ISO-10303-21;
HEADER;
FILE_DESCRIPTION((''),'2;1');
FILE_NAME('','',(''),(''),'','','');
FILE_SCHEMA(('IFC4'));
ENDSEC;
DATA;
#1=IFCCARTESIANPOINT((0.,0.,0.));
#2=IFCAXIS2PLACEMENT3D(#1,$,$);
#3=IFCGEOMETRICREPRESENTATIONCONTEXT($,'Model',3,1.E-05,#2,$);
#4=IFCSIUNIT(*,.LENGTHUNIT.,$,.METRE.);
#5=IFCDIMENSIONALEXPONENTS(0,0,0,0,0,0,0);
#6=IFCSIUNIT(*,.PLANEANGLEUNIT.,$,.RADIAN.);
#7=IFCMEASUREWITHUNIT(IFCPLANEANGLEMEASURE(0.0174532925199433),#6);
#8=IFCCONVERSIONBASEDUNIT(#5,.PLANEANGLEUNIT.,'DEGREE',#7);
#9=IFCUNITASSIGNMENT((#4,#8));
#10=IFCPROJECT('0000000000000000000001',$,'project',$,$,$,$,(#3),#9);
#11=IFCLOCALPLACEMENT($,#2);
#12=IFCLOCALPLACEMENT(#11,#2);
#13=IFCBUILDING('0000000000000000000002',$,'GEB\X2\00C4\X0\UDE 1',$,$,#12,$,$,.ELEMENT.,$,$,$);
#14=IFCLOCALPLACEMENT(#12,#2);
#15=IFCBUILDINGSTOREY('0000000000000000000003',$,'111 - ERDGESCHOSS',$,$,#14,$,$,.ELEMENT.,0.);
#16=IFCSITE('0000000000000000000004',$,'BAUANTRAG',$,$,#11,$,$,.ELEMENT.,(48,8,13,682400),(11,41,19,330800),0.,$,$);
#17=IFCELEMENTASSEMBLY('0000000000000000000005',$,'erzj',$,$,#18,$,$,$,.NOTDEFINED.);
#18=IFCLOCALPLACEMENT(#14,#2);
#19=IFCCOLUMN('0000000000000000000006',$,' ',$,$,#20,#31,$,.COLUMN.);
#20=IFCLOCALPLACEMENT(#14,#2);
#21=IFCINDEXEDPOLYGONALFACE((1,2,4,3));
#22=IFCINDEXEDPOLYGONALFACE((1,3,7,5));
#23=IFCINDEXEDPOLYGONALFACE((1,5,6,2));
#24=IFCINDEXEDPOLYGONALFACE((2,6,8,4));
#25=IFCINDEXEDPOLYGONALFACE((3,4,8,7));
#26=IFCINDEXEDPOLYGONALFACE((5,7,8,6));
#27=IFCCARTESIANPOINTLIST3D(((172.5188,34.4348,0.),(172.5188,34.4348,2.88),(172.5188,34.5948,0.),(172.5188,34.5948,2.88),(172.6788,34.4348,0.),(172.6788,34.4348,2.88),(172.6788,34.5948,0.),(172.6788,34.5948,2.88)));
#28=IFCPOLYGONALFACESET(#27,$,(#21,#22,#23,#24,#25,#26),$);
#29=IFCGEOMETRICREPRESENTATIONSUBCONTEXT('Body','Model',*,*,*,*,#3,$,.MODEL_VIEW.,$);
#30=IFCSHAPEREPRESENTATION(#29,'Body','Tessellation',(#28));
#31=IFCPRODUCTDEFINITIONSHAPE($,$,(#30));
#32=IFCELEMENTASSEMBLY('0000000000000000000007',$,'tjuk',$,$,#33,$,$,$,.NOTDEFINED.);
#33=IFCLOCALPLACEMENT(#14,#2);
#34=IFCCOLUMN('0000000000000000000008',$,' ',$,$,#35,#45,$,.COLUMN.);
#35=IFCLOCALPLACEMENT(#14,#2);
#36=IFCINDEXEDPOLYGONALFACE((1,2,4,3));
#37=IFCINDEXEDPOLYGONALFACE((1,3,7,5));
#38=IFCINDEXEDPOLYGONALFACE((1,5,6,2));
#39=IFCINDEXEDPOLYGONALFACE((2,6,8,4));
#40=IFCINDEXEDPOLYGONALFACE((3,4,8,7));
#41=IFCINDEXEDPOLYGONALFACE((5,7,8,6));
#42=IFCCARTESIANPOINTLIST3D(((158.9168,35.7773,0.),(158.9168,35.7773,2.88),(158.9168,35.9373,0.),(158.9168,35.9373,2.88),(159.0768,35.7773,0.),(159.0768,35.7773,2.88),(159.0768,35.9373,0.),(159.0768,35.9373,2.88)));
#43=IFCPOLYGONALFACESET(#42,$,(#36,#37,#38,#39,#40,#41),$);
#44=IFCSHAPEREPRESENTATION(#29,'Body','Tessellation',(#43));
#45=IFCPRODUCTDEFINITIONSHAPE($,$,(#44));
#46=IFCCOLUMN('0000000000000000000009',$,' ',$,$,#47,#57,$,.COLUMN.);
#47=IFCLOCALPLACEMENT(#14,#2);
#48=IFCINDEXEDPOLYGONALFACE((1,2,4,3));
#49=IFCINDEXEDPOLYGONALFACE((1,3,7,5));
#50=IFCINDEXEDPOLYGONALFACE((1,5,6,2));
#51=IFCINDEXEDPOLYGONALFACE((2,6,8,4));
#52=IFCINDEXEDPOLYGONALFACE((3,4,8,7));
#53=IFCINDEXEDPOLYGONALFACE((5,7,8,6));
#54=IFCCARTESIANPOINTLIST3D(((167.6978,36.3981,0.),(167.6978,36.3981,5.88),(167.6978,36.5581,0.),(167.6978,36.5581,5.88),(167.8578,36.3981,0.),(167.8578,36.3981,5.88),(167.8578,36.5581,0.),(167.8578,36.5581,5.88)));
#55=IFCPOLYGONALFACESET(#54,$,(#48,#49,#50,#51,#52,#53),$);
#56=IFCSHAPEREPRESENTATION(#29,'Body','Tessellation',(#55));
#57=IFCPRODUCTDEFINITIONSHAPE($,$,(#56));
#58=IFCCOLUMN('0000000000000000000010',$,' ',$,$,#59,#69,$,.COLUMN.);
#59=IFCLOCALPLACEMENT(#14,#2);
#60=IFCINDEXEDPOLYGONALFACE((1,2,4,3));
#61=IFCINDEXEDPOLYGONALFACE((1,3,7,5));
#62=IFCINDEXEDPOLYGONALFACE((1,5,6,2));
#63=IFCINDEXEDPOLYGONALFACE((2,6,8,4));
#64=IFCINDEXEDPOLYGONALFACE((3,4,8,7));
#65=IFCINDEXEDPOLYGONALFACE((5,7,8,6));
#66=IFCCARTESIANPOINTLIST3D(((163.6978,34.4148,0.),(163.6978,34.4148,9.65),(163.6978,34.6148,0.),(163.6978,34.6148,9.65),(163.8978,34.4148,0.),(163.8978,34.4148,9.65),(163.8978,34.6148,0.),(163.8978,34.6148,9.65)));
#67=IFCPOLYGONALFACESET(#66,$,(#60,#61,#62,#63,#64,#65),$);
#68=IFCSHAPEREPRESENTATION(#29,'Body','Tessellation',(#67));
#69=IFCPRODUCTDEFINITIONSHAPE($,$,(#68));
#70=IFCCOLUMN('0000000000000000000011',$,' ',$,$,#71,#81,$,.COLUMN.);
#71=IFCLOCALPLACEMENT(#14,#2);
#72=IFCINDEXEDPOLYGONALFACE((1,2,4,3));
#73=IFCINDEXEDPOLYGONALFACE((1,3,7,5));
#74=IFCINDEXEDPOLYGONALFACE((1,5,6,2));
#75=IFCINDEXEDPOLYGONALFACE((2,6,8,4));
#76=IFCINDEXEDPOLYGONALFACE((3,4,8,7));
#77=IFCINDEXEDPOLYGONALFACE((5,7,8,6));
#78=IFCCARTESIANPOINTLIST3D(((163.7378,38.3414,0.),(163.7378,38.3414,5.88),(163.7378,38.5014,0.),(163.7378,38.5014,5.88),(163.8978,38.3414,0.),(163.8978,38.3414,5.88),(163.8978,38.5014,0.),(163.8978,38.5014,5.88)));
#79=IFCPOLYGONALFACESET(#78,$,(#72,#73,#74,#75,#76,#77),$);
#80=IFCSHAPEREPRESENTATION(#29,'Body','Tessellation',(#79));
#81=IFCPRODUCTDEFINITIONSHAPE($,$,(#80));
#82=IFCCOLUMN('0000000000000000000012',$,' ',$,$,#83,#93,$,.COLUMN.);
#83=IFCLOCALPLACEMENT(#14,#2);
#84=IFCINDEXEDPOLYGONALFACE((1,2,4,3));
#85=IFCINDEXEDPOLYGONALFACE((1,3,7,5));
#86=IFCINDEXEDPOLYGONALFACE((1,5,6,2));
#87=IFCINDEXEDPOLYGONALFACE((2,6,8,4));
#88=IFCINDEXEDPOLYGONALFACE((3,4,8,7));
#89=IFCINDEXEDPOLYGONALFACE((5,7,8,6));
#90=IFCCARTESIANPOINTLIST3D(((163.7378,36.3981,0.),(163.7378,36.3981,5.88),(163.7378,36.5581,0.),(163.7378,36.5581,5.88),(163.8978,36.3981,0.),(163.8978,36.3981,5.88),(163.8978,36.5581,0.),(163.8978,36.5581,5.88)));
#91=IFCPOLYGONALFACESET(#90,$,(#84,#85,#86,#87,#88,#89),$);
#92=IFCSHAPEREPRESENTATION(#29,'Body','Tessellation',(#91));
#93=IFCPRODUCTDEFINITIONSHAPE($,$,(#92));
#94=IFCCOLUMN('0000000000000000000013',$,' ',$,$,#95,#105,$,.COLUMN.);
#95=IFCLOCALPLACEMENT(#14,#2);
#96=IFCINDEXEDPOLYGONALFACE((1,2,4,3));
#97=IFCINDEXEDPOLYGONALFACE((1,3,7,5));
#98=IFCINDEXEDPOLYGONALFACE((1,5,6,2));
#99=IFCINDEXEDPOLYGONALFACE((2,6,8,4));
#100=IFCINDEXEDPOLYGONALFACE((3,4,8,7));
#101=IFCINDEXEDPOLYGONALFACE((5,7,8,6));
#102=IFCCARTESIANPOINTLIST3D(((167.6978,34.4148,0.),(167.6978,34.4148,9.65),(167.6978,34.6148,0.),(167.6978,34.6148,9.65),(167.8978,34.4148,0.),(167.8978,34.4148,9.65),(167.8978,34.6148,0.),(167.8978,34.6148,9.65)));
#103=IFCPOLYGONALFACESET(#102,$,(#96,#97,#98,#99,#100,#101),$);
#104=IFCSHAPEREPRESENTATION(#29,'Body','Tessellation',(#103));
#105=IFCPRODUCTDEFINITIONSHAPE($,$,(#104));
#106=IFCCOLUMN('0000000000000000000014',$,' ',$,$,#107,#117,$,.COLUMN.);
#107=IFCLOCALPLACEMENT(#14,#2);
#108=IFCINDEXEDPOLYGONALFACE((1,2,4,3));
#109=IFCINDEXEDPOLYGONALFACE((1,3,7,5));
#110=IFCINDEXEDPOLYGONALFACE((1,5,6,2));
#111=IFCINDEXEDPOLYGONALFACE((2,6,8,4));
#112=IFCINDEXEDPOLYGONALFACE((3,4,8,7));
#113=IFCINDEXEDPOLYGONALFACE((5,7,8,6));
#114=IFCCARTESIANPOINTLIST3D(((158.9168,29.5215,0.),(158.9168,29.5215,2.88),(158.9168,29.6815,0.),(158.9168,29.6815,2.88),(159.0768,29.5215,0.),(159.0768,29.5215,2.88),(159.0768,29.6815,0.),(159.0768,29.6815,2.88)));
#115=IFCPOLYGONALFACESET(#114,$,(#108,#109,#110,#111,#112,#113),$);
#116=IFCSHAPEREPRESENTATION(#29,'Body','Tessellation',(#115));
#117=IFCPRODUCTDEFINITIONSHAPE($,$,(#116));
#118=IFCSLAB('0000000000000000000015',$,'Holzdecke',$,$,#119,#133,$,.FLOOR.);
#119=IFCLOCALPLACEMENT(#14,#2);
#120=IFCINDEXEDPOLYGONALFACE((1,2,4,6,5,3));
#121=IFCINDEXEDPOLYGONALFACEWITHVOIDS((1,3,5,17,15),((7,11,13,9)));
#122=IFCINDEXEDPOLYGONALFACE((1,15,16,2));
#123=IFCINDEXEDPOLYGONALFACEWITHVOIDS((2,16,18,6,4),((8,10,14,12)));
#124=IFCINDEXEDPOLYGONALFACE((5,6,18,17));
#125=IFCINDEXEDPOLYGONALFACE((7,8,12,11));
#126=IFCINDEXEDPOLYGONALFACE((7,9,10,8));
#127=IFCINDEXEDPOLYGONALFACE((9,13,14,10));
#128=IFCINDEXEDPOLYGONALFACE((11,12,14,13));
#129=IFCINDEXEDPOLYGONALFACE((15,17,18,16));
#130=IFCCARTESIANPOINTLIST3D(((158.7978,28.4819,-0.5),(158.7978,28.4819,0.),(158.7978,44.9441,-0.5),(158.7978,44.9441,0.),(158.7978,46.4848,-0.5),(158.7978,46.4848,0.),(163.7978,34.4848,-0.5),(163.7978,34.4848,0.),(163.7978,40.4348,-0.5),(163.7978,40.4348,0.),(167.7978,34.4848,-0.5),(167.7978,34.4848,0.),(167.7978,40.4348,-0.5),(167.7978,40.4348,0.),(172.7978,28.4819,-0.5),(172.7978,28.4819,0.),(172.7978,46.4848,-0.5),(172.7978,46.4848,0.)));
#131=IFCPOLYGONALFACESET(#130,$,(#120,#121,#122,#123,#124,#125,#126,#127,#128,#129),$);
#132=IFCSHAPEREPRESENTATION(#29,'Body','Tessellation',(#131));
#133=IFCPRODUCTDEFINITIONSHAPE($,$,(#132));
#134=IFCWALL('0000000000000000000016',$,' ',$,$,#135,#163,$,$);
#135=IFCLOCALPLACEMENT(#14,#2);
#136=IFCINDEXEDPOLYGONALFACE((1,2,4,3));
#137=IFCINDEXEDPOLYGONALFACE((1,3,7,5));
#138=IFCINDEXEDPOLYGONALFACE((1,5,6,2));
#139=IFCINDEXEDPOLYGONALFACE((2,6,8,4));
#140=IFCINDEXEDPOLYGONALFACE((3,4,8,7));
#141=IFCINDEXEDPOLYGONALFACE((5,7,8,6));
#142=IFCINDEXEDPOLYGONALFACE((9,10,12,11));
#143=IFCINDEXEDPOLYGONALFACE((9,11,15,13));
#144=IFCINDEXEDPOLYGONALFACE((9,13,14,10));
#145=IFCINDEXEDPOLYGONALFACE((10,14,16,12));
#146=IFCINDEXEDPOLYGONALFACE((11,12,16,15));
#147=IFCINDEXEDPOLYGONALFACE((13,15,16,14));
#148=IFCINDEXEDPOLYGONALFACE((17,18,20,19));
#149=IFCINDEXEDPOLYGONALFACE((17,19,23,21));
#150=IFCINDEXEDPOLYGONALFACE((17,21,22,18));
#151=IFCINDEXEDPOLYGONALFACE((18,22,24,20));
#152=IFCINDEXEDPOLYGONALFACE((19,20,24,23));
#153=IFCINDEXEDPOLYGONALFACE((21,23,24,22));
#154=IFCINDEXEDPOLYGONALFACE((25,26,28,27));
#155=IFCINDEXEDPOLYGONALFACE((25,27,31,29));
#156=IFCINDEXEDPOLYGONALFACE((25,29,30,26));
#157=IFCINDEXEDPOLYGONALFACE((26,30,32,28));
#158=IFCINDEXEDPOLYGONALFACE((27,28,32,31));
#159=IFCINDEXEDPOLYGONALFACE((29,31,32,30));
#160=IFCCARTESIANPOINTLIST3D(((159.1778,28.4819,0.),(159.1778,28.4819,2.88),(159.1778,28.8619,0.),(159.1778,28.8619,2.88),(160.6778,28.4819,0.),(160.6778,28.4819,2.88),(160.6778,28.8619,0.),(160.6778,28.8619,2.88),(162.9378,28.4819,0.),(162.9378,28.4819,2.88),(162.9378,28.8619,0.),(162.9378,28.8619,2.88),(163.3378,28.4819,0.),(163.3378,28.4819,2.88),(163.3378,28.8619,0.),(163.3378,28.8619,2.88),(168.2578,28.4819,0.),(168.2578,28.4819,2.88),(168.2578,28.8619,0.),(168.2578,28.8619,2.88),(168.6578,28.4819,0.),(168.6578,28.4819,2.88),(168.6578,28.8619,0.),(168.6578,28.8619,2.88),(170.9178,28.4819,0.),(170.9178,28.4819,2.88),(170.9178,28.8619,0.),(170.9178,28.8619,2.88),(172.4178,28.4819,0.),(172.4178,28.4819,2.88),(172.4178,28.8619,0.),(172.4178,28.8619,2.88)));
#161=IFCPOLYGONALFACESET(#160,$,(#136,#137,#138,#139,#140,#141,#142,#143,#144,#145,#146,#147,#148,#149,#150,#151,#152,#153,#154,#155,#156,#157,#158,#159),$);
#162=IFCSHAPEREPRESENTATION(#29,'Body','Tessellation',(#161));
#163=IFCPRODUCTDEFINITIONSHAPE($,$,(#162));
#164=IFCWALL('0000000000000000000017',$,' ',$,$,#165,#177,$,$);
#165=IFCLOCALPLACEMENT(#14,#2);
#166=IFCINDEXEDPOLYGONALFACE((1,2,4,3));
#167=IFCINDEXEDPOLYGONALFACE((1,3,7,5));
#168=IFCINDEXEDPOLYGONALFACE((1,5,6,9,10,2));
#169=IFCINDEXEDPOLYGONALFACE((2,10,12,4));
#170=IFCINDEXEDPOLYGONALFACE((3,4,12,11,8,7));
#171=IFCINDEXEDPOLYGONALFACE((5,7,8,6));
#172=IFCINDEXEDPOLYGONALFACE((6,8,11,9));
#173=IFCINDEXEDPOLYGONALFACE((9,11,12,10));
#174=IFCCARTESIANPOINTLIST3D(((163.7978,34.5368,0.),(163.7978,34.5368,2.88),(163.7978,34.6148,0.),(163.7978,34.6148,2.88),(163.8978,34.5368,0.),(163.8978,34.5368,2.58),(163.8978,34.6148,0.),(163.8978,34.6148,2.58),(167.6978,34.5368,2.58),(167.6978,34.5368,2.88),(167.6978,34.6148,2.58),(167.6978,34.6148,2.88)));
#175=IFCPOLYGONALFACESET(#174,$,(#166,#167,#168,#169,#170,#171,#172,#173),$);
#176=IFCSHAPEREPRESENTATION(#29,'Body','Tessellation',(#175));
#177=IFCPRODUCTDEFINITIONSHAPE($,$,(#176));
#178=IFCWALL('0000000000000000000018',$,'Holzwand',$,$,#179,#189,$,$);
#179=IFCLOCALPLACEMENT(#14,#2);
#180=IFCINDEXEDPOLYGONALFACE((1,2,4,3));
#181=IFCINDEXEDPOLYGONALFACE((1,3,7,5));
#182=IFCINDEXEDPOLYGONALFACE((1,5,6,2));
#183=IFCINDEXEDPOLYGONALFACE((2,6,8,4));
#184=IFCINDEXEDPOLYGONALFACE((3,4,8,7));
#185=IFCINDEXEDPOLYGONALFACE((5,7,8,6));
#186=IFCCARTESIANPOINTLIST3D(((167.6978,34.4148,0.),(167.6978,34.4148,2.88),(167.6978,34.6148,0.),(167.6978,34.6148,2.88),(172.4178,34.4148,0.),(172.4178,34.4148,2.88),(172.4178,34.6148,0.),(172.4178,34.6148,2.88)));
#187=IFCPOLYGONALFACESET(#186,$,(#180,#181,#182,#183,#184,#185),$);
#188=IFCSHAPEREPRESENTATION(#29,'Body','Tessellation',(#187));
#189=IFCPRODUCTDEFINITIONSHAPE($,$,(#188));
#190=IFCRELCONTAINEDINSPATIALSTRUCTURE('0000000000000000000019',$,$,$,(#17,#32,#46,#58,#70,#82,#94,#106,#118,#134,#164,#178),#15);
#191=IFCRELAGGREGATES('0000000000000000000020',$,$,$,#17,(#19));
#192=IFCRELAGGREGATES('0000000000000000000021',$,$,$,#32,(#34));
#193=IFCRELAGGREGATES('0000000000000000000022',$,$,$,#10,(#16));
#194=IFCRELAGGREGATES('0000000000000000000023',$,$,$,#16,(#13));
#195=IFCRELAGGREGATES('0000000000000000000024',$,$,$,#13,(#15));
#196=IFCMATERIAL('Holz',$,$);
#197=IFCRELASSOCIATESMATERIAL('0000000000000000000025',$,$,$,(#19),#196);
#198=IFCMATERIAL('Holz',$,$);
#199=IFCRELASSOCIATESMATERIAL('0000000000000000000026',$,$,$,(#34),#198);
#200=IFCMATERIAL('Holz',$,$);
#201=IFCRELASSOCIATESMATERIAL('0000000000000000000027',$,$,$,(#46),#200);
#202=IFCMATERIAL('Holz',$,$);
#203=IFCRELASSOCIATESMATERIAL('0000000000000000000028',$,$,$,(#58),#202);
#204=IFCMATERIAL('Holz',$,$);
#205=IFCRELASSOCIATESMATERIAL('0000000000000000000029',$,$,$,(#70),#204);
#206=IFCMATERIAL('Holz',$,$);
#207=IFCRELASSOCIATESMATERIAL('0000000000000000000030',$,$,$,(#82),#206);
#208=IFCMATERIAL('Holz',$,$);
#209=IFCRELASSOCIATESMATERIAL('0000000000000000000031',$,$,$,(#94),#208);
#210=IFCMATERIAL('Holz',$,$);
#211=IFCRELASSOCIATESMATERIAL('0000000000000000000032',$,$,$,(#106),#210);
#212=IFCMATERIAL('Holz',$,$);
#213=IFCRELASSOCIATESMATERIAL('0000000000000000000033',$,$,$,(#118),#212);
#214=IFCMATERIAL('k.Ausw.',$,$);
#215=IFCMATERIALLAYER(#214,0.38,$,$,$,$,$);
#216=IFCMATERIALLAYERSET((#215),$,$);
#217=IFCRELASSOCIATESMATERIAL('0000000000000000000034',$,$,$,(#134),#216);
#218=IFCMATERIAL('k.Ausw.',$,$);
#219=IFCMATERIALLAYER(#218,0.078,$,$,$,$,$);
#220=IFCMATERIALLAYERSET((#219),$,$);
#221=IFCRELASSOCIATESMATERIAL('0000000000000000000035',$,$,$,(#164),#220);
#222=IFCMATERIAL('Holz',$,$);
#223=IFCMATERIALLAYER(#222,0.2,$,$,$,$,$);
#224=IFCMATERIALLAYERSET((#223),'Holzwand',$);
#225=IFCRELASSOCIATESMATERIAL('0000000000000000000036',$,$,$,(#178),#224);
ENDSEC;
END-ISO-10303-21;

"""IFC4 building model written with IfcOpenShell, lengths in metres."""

from ifc_helpers import new_model, entity, si_unit, converted_unit, frame, frame_2d, origin, origin_with_axes, place, context, subcontext, project, spatial, polyline, rectangle, outline, extrude, material, layer, layer_set, layer_usage, element, aggregate, save


model = new_model("IFC4")

# Units and contexts
model_context = context("Model", 3, precision=1e-05, world=origin())
body_context = subcontext(model_context, "Body", "Model", "MODEL_VIEW")
ifc_project = project(units=[si_unit("LENGTHUNIT", "METRE"), converted_unit("PLANEANGLEUNIT", "DEGREE", entity("IfcPlaneAngleMeasure", 0.0174532925199433), si_unit("PLANEANGLEUNIT", "RADIAN"), dimensions=[0, 0, 0, 0, 0, 0, 0])], contexts=[model_context])

# Site, building, storey
site_placement = place(None, origin())
site = spatial("IfcSite", under=ifc_project, at=site_placement, Name="BAUANTRAG", CompositionType="ELEMENT", RefLatitude=(48, 8, 13, 682400), RefLongitude=(11, 41, 19, 330800), RefElevation=0.0)
building_placement = place(site_placement, origin())
building = spatial("IfcBuilding", under=site, at=building_placement, Name="GEBÄUDE 1", CompositionType="ELEMENT")
storey_placement = place(building_placement, origin())
storey = spatial("IfcBuildingStorey", under=building, at=storey_placement, Name="111 - ERDGESCHOSS", CompositionType="ELEMENT", Elevation=0.0)

# Element assemblies, columns
assembly_1_placement = place(storey_placement, origin())
assembly_1 = element("IfcElementAssembly", 1, at=assembly_1_placement, inside=storey, Name="erzj", PredefinedType="NOTDEFINED")
ifc_material_1 = material(Name="Holz")
column_1_placement = place(assembly_1_placement, frame((172.5188, 34.4348, 0.0)))
column_1 = element("IfcColumn", 2, at=column_1_placement, material=ifc_material_1, Name=" ", PredefinedType="COLUMN", context=body_context, shape_type="SweptSolid", body=[
    extrude(rectangle(XDim=0.16, YDim=0.16, at=frame_2d((0.08, 0.08), x_axis=(1.0, 0.0))), origin_with_axes(), (0.0, 0.0, 1.0), 2.88),
])
aggregate(assembly_1, [column_1])
assembly_2_placement = place(storey_placement, origin())
assembly_2 = element("IfcElementAssembly", 3, at=assembly_2_placement, inside=storey, Name="tjuk", PredefinedType="NOTDEFINED")
ifc_material_2 = material(Name="Holz")
column_2_placement = place(assembly_2_placement, frame((158.9168, 35.7773, 0.0)))
column_2 = element("IfcColumn", 4, at=column_2_placement, material=ifc_material_2, Name=" ", PredefinedType="COLUMN", context=body_context, shape_type="SweptSolid", body=[
    extrude(rectangle(XDim=0.16, YDim=0.16, at=frame_2d((0.08, 0.08), x_axis=(1.0, 0.0))), origin_with_axes(), (0.0, 0.0, 1.0), 2.88),
])
aggregate(assembly_2, [column_2])

# Columns
ifc_material_3 = material(Name="Holz")
column_3_placement = place(storey_placement, frame((167.6978, 36.3981, 0.0)))
element("IfcColumn", 5, at=column_3_placement, inside=storey, material=ifc_material_3, Name=" ", PredefinedType="COLUMN", context=body_context, shape_type="SweptSolid", body=[
    extrude(rectangle(XDim=0.16, YDim=0.16, at=frame_2d((0.08, 0.08), x_axis=(1.0, 0.0))), origin_with_axes(), (0.0, 0.0, 1.0), 5.88),
])
ifc_material_4 = material(Name="Holz")
column_4_placement = place(storey_placement, frame((163.6978, 34.4148, 0.0)))
element("IfcColumn", 6, at=column_4_placement, inside=storey, material=ifc_material_4, Name=" ", PredefinedType="COLUMN", context=body_context, shape_type="SweptSolid", body=[
    extrude(rectangle(XDim=0.2, YDim=0.2, at=frame_2d((0.1, 0.1), x_axis=(1.0, 0.0))), origin_with_axes(), (0.0, 0.0, 1.0), 9.65),
])
ifc_material_5 = material(Name="Holz")
column_5_placement = place(storey_placement, frame((163.7378, 38.3414, 0.0)))
element("IfcColumn", 7, at=column_5_placement, inside=storey, material=ifc_material_5, Name=" ", PredefinedType="COLUMN", context=body_context, shape_type="SweptSolid", body=[
    extrude(rectangle(XDim=0.16, YDim=0.16, at=frame_2d((0.08, 0.08), x_axis=(1.0, 0.0))), origin_with_axes(), (0.0, 0.0, 1.0), 5.88),
])
ifc_material_6 = material(Name="Holz")
column_6_placement = place(storey_placement, frame((163.7378, 36.3981, 0.0)))
element("IfcColumn", 8, at=column_6_placement, inside=storey, material=ifc_material_6, Name=" ", PredefinedType="COLUMN", context=body_context, shape_type="SweptSolid", body=[
    extrude(rectangle(XDim=0.16, YDim=0.16, at=frame_2d((0.08, 0.08), x_axis=(1.0, 0.0))), origin_with_axes(), (0.0, 0.0, 1.0), 5.88),
])
ifc_material_7 = material(Name="Holz")
column_7_placement = place(storey_placement, frame((167.6978, 34.4148, 0.0)))
element("IfcColumn", 9, at=column_7_placement, inside=storey, material=ifc_material_7, Name=" ", PredefinedType="COLUMN", context=body_context, shape_type="SweptSolid", body=[
    extrude(rectangle(XDim=0.2, YDim=0.2, at=frame_2d((0.1, 0.1), x_axis=(1.0, 0.0))), origin_with_axes(), (0.0, 0.0, 1.0), 9.65),
])
ifc_material_8 = material(Name="Holz")
column_8_placement = place(storey_placement, frame((158.9168, 29.5215, 0.0)))
element("IfcColumn", 10, at=column_8_placement, inside=storey, material=ifc_material_8, Name=" ", PredefinedType="COLUMN", context=body_context, shape_type="SweptSolid", body=[
    extrude(rectangle(XDim=0.16, YDim=0.16, at=frame_2d((0.08, 0.08), x_axis=(1.0, 0.0))), origin_with_axes(), (0.0, 0.0, 1.0), 2.88),
])

# Slab
ifc_material_9 = material(Name="Holz")
slab_1_placement = place(storey_placement, frame((158.7978, 28.4819, -0.5)))
element("IfcSlab", 11, at=slab_1_placement, inside=storey, material=ifc_material_9, Name="Holzdecke", PredefinedType="FLOOR", context=body_context, shape_type="SweptSolid", body=[
    extrude(outline(polyline([(0.0, 16.4622), (0.0, 0.0), (14.0, 0.0), (14.0, 18.0029), (0.0, 18.0029), (0.0, 16.4622)]), holes=[polyline([(5.0, 11.9529), (9.0, 11.9529), (9.0, 6.0029), (5.0, 6.0029), (5.0, 11.9529)])]), origin_with_axes(), (0.0, 0.0, 1.0), 0.5),
])

# Wall, openings
ifc_material_10 = material(Name="k.Ausw.")
ifc_layer_1 = layer(ifc_material_10, 0.38)
ifc_layer_set_1 = layer_set([ifc_layer_1])
ifc_layer_usage_1 = layer_usage(ifc_layer_set_1, "AXIS2", "POSITIVE", 0.0)
wall_1_placement = place(storey_placement, frame((159.1778, 28.4819, 0.0)))
wall_1 = element("IfcWall", 12, at=wall_1_placement, inside=storey, material=ifc_layer_usage_1, Name=" ", context=body_context, shape_type="SweptSolid", body=[
    extrude(rectangle(XDim=13.24, YDim=0.38, at=frame_2d((6.62, 0.19), x_axis=(1.0, 0.0))), origin_with_axes(), (0.0, 0.0, 1.0), 2.88),
])
opening_1_placement = place(wall_1_placement, frame((9.48, 0.0, 0.0), z_axis=(0.0, 1.0, 0.0), x_axis=(0.0, 0.0, 1.0)))
element("IfcOpeningElement", 13, at=opening_1_placement, cuts=wall_1, ObjectType="Opening", context=body_context, shape_type="SweptSolid", body=[
    extrude(outline(polyline([(0.0, 2.26), (2.88, 2.26), (2.88, 0.0), (0.0, 0.0), (0.0, 2.26)])), origin_with_axes(), (0.0, 0.0, 1.0), 0.38),
])
opening_2_placement = place(wall_1_placement, frame((1.5, 0.0, 0.0), z_axis=(0.0, 1.0, 0.0), x_axis=(0.0, 0.0, 1.0)))
element("IfcOpeningElement", 14, at=opening_2_placement, cuts=wall_1, ObjectType="Opening", context=body_context, shape_type="SweptSolid", body=[
    extrude(outline(polyline([(0.0, 2.26), (2.88, 2.26), (2.88, 0.0), (0.0, 0.0), (0.0, 2.26)])), origin_with_axes(), (0.0, 0.0, 1.0), 0.38),
])
opening_3_placement = place(wall_1_placement, frame((4.16, 0.0, 0.0), z_axis=(0.0, 1.0, 0.0), x_axis=(0.0, 0.0, 1.0)))
element("IfcOpeningElement", 15, at=opening_3_placement, cuts=wall_1, ObjectType="Opening", context=body_context, shape_type="SweptSolid", body=[
    extrude(outline(polyline([(0.0, 4.92), (2.88, 4.92), (2.88, 0.0), (0.0, 0.0), (0.0, 4.92)])), origin_with_axes(), (0.0, 0.0, 1.0), 0.38),
])

# Wall, opening
ifc_material_11 = material(Name="k.Ausw.")
ifc_layer_2 = layer(ifc_material_11, 0.078)
ifc_layer_set_2 = layer_set([ifc_layer_2])
ifc_layer_usage_2 = layer_usage(ifc_layer_set_2, "AXIS2", "POSITIVE", 0.0)
wall_2_placement = place(storey_placement, frame((163.7978, 34.5368, 0.0)))
wall_2 = element("IfcWall", 16, at=wall_2_placement, inside=storey, material=ifc_layer_usage_2, Name=" ", context=body_context, shape_type="SweptSolid", body=[
    extrude(rectangle(XDim=3.9, YDim=0.078, at=frame_2d((1.95, 0.039), x_axis=(1.0, 0.0))), origin_with_axes(), (0.0, 0.0, 1.0), 2.88),
])
opening_4_placement = place(wall_2_placement, frame((0.1, 0.0, -0.14), z_axis=(0.0, 1.0, 0.0), x_axis=(0.0, 0.0, 1.0)))
element("IfcOpeningElement", 17, at=opening_4_placement, cuts=wall_2, ObjectType="Opening", context=body_context, shape_type="SweptSolid", body=[
    extrude(outline(polyline([(0.0, 3.8), (2.72, 3.8), (2.72, 0.0), (0.0, 0.0), (0.0, 3.8)])), origin_with_axes(), (0.0, 0.0, 1.0), 0.078),
])

# Wall
ifc_material_12 = material(Name="Holz")
ifc_layer_3 = layer(ifc_material_12, 0.2)
ifc_layer_set_3 = layer_set([ifc_layer_3], Name="Holzwand")
ifc_layer_usage_3 = layer_usage(ifc_layer_set_3, "AXIS2", "POSITIVE", 0.0)
wall_3_placement = place(storey_placement, frame((167.6978, 34.4148, 0.0)))
element("IfcWall", 18, at=wall_3_placement, inside=storey, material=ifc_layer_usage_3, Name="Holzwand", context=body_context, shape_type="SweptSolid", body=[
    extrude(rectangle(XDim=4.72, YDim=0.2, at=frame_2d((2.36, 0.1), x_axis=(1.0, 0.0))), origin_with_axes(), (0.0, 0.0, 1.0), 2.88),
])

save(model, "model.ifc")
